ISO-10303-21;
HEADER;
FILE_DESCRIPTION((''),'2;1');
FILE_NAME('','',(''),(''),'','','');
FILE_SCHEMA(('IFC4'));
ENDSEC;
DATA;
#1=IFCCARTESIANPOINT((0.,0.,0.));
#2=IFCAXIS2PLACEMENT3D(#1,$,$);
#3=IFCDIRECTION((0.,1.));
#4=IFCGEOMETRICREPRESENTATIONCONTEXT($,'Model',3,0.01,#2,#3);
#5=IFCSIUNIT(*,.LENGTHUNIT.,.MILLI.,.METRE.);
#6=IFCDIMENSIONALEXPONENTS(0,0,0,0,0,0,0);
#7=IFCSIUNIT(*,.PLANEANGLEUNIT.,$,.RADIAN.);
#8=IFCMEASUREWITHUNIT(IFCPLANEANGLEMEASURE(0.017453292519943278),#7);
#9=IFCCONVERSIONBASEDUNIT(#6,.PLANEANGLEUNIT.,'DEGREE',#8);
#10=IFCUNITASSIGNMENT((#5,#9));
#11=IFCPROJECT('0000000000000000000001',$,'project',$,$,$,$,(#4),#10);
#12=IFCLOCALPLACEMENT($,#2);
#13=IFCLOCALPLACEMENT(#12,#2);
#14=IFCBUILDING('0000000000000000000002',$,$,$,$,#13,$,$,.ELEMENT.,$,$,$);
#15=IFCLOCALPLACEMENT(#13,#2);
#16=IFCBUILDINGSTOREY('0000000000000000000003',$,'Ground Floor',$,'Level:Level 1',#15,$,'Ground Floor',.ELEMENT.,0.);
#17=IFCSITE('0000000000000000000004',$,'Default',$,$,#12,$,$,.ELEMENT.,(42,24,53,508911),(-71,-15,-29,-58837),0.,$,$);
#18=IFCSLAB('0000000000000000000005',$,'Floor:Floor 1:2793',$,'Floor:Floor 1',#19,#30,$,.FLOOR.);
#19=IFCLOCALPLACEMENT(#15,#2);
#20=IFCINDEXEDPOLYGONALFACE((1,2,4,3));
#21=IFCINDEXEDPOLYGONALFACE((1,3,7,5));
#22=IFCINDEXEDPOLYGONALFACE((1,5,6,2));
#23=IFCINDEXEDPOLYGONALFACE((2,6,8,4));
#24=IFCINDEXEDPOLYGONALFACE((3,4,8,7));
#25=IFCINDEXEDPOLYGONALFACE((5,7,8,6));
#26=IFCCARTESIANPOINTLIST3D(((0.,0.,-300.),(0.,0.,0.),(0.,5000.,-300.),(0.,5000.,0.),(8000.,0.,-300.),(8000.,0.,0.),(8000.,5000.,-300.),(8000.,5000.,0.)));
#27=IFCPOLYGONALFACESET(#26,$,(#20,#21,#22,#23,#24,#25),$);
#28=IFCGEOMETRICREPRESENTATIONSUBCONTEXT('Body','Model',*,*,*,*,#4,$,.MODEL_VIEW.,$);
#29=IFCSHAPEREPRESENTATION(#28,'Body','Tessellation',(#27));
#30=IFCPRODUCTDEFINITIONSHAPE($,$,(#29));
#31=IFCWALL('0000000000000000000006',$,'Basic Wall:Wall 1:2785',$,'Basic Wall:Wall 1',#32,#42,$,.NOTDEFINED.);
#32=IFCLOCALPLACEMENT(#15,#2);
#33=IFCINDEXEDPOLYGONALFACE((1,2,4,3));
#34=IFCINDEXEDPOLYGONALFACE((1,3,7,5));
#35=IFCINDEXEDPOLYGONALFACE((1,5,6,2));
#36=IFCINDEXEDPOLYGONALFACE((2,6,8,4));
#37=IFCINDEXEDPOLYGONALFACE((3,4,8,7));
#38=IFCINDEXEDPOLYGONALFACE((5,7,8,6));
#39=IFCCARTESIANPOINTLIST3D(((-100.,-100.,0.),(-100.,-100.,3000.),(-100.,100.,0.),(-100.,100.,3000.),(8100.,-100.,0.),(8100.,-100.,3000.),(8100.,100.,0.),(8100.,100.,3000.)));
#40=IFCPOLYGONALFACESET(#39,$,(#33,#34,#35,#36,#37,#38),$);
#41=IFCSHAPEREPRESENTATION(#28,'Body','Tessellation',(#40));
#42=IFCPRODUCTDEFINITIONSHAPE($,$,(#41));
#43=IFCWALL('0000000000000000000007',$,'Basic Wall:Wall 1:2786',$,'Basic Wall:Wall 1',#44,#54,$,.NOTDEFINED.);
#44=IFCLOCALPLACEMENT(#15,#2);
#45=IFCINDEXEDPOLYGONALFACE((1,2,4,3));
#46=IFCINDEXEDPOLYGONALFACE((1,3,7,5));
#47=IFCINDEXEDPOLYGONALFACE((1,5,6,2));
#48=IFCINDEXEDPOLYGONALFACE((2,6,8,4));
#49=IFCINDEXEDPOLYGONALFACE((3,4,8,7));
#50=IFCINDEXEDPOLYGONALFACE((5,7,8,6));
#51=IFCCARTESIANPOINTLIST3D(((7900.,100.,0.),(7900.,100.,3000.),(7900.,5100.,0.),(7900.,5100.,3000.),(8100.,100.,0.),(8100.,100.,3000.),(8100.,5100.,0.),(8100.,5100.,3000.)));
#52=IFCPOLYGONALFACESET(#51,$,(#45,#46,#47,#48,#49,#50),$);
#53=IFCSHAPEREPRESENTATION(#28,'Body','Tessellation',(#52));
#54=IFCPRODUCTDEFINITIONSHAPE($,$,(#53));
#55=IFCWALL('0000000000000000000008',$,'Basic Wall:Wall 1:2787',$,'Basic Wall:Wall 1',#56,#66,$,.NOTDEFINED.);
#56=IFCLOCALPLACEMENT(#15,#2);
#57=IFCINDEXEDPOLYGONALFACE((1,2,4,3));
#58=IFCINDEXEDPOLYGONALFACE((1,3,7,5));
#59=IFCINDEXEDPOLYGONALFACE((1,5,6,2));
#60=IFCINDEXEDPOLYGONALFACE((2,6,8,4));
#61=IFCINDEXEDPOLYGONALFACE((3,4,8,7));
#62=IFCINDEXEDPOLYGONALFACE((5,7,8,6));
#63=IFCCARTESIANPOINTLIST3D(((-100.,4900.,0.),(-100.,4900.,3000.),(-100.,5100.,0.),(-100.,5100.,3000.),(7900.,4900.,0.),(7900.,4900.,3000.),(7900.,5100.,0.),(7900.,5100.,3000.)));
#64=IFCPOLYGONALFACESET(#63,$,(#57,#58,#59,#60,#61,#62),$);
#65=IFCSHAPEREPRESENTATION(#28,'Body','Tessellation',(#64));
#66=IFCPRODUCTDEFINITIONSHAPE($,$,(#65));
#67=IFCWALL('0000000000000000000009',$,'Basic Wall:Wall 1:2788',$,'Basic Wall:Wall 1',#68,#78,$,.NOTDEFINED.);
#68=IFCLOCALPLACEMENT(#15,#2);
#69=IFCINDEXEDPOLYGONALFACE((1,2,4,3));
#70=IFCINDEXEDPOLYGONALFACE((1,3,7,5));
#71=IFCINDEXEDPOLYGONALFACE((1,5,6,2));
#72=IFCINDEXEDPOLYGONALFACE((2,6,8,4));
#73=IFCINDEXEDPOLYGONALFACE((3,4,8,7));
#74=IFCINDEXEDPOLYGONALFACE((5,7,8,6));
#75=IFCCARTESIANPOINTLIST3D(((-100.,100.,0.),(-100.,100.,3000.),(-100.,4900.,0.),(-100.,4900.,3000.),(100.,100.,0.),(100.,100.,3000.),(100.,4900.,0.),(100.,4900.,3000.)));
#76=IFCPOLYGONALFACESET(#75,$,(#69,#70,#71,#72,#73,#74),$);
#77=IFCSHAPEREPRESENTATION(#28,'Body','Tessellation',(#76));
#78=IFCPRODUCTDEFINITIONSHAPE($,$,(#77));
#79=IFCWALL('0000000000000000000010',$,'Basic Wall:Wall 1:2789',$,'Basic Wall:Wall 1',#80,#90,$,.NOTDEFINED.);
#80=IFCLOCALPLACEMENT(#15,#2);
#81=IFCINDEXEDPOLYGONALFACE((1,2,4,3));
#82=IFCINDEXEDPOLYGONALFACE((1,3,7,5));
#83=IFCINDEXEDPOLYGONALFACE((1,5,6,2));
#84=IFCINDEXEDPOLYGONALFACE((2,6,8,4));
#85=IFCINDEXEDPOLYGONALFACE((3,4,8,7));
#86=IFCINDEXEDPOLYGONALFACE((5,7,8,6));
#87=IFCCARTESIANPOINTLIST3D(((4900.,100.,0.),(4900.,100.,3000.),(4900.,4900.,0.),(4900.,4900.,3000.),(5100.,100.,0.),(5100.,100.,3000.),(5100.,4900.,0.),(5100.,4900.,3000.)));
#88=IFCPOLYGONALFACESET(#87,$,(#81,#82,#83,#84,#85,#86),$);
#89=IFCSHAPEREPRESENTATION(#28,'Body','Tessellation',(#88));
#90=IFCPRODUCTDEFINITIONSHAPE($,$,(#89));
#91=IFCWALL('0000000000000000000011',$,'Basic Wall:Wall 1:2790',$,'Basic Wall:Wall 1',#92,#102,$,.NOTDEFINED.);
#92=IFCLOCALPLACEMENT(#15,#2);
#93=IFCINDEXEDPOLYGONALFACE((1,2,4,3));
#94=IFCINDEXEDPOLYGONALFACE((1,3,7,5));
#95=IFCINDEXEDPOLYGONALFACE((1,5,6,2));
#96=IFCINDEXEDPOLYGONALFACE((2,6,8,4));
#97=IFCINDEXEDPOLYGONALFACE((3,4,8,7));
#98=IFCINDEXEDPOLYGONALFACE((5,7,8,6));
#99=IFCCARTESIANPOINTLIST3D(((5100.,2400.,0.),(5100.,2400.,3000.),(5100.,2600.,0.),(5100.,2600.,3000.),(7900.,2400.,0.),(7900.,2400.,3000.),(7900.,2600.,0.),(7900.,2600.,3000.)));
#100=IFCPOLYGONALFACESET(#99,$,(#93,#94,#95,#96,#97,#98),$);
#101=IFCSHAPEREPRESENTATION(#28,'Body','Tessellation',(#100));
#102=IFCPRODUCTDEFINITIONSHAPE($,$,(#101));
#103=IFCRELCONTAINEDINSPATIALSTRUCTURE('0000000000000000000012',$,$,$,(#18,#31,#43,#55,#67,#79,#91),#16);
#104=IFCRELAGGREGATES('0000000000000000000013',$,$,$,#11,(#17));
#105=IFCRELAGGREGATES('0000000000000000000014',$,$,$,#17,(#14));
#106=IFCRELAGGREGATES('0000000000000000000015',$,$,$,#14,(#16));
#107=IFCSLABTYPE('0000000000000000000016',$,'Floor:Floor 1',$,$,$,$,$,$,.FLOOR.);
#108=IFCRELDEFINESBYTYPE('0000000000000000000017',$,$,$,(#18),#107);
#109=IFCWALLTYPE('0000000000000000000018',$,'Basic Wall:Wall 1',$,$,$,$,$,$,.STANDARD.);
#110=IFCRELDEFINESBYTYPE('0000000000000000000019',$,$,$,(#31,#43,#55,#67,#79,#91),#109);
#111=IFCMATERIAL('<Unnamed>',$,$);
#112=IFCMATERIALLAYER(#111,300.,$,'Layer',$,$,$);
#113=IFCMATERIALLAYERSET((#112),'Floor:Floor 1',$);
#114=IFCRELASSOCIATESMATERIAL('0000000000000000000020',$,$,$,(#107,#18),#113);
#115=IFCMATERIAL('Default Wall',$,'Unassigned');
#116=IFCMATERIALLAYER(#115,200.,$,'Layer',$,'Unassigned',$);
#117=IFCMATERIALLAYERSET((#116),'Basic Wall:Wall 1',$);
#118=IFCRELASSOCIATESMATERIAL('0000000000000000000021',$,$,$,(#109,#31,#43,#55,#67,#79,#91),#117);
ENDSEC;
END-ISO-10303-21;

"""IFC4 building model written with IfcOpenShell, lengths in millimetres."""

from ifc_helpers import new_model, entity, si_unit, converted_unit, direction, frame, frame_2d, origin, origin_2d_with_axis, place, context, subcontext, project, spatial, rectangle, extrude, material, layer, layer_set, layer_usage, type_object, element, save


model = new_model("IFC4")

# Units and contexts
model_context = context("Model", 3, precision=0.01, world=origin(), true_north=direction((0.0, 1.0)))
body_context = subcontext(model_context, "Body", "Model", "MODEL_VIEW")
ifc_project = project(units=[si_unit("LENGTHUNIT", "METRE", prefix="MILLI"), converted_unit("PLANEANGLEUNIT", "DEGREE", entity("IfcPlaneAngleMeasure", 0.017453292519943278), si_unit("PLANEANGLEUNIT", "RADIAN"), dimensions=[0, 0, 0, 0, 0, 0, 0])], contexts=[model_context])

# Site, building, storey
site_placement = place(None, origin())
site = spatial("IfcSite", under=ifc_project, at=site_placement, Name="Default", CompositionType="ELEMENT", RefLatitude=(42, 24, 53, 508911), RefLongitude=(-71, -15, -29, -58837), RefElevation=0.0)
building_placement = place(site_placement, origin())
building = spatial("IfcBuilding", under=site, at=building_placement, CompositionType="ELEMENT")
storey_placement = place(building_placement, origin())
storey = spatial("IfcBuildingStorey", under=building, at=storey_placement, Name="Ground Floor", ObjectType="Level:Level 1", LongName="Ground Floor", CompositionType="ELEMENT", Elevation=0.0)

# Slab
ifc_material_1 = material(Name="<Unnamed>")
ifc_layer_1 = layer(ifc_material_1, 300.0, Name="Layer")
ifc_layer_set_1 = layer_set([ifc_layer_1], Name="Floor:Floor 1")
ifc_layer_usage_1 = layer_usage(ifc_layer_set_1, "AXIS3", "POSITIVE", 0.0)
slab_type = type_object("IfcSlabType", Name="Floor:Floor 1", PredefinedType="FLOOR", material=ifc_layer_set_1)
slab_placement = place(storey_placement, origin())
element("IfcSlab", 1, at=slab_placement, inside=storey, type_object=slab_type, material=ifc_layer_usage_1, Name="Floor:Floor 1:2793", ObjectType="Floor:Floor 1", PredefinedType="FLOOR", context=body_context, shape_type="SweptSolid", body=[
    extrude(rectangle(XDim=5000.0, YDim=8000.0, at=origin_2d_with_axis()), frame((4000.0, 2500.0, 0.0), z_axis=(0.0, 0.0, -1.0), x_axis=(0.0, 1.0, 0.0)), (0.0, 0.0, 1.0), 300.0),
])

# Walls
ifc_material_2 = material(Name="Default Wall", Category="Unassigned")
ifc_layer_2 = layer(ifc_material_2, 200.0, Name="Layer", Category="Unassigned")
ifc_layer_set_2 = layer_set([ifc_layer_2], Name="Basic Wall:Wall 1")
ifc_layer_usage_2 = layer_usage(ifc_layer_set_2, "AXIS2", "NEGATIVE", 100.0)
wall_type = type_object("IfcWallType", Name="Basic Wall:Wall 1", PredefinedType="STANDARD", material=ifc_layer_set_2)
wall_1_placement = place(storey_placement, frame((-100.0, 0.0, 0.0)))
element("IfcWall", 2, at=wall_1_placement, inside=storey, type_object=wall_type, material=ifc_layer_usage_2, Name="Basic Wall:Wall 1:2785", ObjectType="Basic Wall:Wall 1", PredefinedType="NOTDEFINED", context=body_context, shape_type="SweptSolid", body=[
    extrude(rectangle(XDim=8200.0, YDim=200.0, at=frame_2d((4100.0, 0.0), x_axis=(-1.0, 0.0))), origin(), (0.0, 0.0, 1.0), 3000.0),
])
ifc_layer_usage_3 = layer_usage(ifc_layer_set_2, "AXIS2", "NEGATIVE", 100.0)
wall_2_placement = place(storey_placement, frame((8000.0, 100.0, 0.0), z_axis=(0.0, 0.0, 1.0), x_axis=(0.0, 1.0, 0.0)))
element("IfcWall", 3, at=wall_2_placement, inside=storey, type_object=wall_type, material=ifc_layer_usage_3, Name="Basic Wall:Wall 1:2786", ObjectType="Basic Wall:Wall 1", PredefinedType="NOTDEFINED", context=body_context, shape_type="SweptSolid", body=[
    extrude(rectangle(XDim=5000.0, YDim=200.0, at=frame_2d((2500.0, 0.0), x_axis=(-1.0, 0.0))), origin(), (0.0, 0.0, 1.0), 3000.0),
])
ifc_layer_usage_4 = layer_usage(ifc_layer_set_2, "AXIS2", "NEGATIVE", 100.0)
wall_3_placement = place(storey_placement, frame((7900.0, 5000.0, 0.0), z_axis=(0.0, 0.0, 1.0), x_axis=(-1.0, 0.0, 0.0)))
element("IfcWall", 4, at=wall_3_placement, inside=storey, type_object=wall_type, material=ifc_layer_usage_4, Name="Basic Wall:Wall 1:2787", ObjectType="Basic Wall:Wall 1", PredefinedType="NOTDEFINED", context=body_context, shape_type="SweptSolid", body=[
    extrude(rectangle(XDim=8000.0, YDim=200.0, at=frame_2d((4000.0, 0.0), x_axis=(-1.0, 0.0))), origin(), (0.0, 0.0, 1.0), 3000.0),
])
ifc_layer_usage_5 = layer_usage(ifc_layer_set_2, "AXIS2", "NEGATIVE", 100.0)
wall_4_placement = place(storey_placement, frame((0.0, 4900.0, 0.0), z_axis=(0.0, 0.0, 1.0), x_axis=(0.0, -1.0, 0.0)))
element("IfcWall", 5, at=wall_4_placement, inside=storey, type_object=wall_type, material=ifc_layer_usage_5, Name="Basic Wall:Wall 1:2788", ObjectType="Basic Wall:Wall 1", PredefinedType="NOTDEFINED", context=body_context, shape_type="SweptSolid", body=[
    extrude(rectangle(XDim=4800.0, YDim=200.0, at=frame_2d((2400.0, 0.0), x_axis=(-1.0, 0.0))), origin(), (0.0, 0.0, 1.0), 3000.0),
])
ifc_layer_usage_6 = layer_usage(ifc_layer_set_2, "AXIS2", "NEGATIVE", 100.0)
wall_5_placement = place(storey_placement, frame((5000.0, 100.0, 0.0), z_axis=(0.0, 0.0, 1.0), x_axis=(0.0, 1.0, 0.0)))
element("IfcWall", 6, at=wall_5_placement, inside=storey, type_object=wall_type, material=ifc_layer_usage_6, Name="Basic Wall:Wall 1:2789", ObjectType="Basic Wall:Wall 1", PredefinedType="NOTDEFINED", context=body_context, shape_type="SweptSolid", body=[
    extrude(rectangle(XDim=4800.0, YDim=200.0, at=frame_2d((2400.0, 0.0), x_axis=(-1.0, 0.0))), origin(), (0.0, 0.0, 1.0), 3000.0),
])
ifc_layer_usage_7 = layer_usage(ifc_layer_set_2, "AXIS2", "NEGATIVE", 100.0)
wall_6_placement = place(storey_placement, frame((5100.0, 2500.0, 0.0)))
element("IfcWall", 7, at=wall_6_placement, inside=storey, type_object=wall_type, material=ifc_layer_usage_7, Name="Basic Wall:Wall 1:2790", ObjectType="Basic Wall:Wall 1", PredefinedType="NOTDEFINED", context=body_context, shape_type="SweptSolid", body=[
    extrude(rectangle(XDim=2800.0, YDim=200.0, at=frame_2d((1400.0, 0.0), x_axis=(-1.0, 0.0))), origin(), (0.0, 0.0, 1.0), 3000.0),
])

save(model, "model.ifc")
